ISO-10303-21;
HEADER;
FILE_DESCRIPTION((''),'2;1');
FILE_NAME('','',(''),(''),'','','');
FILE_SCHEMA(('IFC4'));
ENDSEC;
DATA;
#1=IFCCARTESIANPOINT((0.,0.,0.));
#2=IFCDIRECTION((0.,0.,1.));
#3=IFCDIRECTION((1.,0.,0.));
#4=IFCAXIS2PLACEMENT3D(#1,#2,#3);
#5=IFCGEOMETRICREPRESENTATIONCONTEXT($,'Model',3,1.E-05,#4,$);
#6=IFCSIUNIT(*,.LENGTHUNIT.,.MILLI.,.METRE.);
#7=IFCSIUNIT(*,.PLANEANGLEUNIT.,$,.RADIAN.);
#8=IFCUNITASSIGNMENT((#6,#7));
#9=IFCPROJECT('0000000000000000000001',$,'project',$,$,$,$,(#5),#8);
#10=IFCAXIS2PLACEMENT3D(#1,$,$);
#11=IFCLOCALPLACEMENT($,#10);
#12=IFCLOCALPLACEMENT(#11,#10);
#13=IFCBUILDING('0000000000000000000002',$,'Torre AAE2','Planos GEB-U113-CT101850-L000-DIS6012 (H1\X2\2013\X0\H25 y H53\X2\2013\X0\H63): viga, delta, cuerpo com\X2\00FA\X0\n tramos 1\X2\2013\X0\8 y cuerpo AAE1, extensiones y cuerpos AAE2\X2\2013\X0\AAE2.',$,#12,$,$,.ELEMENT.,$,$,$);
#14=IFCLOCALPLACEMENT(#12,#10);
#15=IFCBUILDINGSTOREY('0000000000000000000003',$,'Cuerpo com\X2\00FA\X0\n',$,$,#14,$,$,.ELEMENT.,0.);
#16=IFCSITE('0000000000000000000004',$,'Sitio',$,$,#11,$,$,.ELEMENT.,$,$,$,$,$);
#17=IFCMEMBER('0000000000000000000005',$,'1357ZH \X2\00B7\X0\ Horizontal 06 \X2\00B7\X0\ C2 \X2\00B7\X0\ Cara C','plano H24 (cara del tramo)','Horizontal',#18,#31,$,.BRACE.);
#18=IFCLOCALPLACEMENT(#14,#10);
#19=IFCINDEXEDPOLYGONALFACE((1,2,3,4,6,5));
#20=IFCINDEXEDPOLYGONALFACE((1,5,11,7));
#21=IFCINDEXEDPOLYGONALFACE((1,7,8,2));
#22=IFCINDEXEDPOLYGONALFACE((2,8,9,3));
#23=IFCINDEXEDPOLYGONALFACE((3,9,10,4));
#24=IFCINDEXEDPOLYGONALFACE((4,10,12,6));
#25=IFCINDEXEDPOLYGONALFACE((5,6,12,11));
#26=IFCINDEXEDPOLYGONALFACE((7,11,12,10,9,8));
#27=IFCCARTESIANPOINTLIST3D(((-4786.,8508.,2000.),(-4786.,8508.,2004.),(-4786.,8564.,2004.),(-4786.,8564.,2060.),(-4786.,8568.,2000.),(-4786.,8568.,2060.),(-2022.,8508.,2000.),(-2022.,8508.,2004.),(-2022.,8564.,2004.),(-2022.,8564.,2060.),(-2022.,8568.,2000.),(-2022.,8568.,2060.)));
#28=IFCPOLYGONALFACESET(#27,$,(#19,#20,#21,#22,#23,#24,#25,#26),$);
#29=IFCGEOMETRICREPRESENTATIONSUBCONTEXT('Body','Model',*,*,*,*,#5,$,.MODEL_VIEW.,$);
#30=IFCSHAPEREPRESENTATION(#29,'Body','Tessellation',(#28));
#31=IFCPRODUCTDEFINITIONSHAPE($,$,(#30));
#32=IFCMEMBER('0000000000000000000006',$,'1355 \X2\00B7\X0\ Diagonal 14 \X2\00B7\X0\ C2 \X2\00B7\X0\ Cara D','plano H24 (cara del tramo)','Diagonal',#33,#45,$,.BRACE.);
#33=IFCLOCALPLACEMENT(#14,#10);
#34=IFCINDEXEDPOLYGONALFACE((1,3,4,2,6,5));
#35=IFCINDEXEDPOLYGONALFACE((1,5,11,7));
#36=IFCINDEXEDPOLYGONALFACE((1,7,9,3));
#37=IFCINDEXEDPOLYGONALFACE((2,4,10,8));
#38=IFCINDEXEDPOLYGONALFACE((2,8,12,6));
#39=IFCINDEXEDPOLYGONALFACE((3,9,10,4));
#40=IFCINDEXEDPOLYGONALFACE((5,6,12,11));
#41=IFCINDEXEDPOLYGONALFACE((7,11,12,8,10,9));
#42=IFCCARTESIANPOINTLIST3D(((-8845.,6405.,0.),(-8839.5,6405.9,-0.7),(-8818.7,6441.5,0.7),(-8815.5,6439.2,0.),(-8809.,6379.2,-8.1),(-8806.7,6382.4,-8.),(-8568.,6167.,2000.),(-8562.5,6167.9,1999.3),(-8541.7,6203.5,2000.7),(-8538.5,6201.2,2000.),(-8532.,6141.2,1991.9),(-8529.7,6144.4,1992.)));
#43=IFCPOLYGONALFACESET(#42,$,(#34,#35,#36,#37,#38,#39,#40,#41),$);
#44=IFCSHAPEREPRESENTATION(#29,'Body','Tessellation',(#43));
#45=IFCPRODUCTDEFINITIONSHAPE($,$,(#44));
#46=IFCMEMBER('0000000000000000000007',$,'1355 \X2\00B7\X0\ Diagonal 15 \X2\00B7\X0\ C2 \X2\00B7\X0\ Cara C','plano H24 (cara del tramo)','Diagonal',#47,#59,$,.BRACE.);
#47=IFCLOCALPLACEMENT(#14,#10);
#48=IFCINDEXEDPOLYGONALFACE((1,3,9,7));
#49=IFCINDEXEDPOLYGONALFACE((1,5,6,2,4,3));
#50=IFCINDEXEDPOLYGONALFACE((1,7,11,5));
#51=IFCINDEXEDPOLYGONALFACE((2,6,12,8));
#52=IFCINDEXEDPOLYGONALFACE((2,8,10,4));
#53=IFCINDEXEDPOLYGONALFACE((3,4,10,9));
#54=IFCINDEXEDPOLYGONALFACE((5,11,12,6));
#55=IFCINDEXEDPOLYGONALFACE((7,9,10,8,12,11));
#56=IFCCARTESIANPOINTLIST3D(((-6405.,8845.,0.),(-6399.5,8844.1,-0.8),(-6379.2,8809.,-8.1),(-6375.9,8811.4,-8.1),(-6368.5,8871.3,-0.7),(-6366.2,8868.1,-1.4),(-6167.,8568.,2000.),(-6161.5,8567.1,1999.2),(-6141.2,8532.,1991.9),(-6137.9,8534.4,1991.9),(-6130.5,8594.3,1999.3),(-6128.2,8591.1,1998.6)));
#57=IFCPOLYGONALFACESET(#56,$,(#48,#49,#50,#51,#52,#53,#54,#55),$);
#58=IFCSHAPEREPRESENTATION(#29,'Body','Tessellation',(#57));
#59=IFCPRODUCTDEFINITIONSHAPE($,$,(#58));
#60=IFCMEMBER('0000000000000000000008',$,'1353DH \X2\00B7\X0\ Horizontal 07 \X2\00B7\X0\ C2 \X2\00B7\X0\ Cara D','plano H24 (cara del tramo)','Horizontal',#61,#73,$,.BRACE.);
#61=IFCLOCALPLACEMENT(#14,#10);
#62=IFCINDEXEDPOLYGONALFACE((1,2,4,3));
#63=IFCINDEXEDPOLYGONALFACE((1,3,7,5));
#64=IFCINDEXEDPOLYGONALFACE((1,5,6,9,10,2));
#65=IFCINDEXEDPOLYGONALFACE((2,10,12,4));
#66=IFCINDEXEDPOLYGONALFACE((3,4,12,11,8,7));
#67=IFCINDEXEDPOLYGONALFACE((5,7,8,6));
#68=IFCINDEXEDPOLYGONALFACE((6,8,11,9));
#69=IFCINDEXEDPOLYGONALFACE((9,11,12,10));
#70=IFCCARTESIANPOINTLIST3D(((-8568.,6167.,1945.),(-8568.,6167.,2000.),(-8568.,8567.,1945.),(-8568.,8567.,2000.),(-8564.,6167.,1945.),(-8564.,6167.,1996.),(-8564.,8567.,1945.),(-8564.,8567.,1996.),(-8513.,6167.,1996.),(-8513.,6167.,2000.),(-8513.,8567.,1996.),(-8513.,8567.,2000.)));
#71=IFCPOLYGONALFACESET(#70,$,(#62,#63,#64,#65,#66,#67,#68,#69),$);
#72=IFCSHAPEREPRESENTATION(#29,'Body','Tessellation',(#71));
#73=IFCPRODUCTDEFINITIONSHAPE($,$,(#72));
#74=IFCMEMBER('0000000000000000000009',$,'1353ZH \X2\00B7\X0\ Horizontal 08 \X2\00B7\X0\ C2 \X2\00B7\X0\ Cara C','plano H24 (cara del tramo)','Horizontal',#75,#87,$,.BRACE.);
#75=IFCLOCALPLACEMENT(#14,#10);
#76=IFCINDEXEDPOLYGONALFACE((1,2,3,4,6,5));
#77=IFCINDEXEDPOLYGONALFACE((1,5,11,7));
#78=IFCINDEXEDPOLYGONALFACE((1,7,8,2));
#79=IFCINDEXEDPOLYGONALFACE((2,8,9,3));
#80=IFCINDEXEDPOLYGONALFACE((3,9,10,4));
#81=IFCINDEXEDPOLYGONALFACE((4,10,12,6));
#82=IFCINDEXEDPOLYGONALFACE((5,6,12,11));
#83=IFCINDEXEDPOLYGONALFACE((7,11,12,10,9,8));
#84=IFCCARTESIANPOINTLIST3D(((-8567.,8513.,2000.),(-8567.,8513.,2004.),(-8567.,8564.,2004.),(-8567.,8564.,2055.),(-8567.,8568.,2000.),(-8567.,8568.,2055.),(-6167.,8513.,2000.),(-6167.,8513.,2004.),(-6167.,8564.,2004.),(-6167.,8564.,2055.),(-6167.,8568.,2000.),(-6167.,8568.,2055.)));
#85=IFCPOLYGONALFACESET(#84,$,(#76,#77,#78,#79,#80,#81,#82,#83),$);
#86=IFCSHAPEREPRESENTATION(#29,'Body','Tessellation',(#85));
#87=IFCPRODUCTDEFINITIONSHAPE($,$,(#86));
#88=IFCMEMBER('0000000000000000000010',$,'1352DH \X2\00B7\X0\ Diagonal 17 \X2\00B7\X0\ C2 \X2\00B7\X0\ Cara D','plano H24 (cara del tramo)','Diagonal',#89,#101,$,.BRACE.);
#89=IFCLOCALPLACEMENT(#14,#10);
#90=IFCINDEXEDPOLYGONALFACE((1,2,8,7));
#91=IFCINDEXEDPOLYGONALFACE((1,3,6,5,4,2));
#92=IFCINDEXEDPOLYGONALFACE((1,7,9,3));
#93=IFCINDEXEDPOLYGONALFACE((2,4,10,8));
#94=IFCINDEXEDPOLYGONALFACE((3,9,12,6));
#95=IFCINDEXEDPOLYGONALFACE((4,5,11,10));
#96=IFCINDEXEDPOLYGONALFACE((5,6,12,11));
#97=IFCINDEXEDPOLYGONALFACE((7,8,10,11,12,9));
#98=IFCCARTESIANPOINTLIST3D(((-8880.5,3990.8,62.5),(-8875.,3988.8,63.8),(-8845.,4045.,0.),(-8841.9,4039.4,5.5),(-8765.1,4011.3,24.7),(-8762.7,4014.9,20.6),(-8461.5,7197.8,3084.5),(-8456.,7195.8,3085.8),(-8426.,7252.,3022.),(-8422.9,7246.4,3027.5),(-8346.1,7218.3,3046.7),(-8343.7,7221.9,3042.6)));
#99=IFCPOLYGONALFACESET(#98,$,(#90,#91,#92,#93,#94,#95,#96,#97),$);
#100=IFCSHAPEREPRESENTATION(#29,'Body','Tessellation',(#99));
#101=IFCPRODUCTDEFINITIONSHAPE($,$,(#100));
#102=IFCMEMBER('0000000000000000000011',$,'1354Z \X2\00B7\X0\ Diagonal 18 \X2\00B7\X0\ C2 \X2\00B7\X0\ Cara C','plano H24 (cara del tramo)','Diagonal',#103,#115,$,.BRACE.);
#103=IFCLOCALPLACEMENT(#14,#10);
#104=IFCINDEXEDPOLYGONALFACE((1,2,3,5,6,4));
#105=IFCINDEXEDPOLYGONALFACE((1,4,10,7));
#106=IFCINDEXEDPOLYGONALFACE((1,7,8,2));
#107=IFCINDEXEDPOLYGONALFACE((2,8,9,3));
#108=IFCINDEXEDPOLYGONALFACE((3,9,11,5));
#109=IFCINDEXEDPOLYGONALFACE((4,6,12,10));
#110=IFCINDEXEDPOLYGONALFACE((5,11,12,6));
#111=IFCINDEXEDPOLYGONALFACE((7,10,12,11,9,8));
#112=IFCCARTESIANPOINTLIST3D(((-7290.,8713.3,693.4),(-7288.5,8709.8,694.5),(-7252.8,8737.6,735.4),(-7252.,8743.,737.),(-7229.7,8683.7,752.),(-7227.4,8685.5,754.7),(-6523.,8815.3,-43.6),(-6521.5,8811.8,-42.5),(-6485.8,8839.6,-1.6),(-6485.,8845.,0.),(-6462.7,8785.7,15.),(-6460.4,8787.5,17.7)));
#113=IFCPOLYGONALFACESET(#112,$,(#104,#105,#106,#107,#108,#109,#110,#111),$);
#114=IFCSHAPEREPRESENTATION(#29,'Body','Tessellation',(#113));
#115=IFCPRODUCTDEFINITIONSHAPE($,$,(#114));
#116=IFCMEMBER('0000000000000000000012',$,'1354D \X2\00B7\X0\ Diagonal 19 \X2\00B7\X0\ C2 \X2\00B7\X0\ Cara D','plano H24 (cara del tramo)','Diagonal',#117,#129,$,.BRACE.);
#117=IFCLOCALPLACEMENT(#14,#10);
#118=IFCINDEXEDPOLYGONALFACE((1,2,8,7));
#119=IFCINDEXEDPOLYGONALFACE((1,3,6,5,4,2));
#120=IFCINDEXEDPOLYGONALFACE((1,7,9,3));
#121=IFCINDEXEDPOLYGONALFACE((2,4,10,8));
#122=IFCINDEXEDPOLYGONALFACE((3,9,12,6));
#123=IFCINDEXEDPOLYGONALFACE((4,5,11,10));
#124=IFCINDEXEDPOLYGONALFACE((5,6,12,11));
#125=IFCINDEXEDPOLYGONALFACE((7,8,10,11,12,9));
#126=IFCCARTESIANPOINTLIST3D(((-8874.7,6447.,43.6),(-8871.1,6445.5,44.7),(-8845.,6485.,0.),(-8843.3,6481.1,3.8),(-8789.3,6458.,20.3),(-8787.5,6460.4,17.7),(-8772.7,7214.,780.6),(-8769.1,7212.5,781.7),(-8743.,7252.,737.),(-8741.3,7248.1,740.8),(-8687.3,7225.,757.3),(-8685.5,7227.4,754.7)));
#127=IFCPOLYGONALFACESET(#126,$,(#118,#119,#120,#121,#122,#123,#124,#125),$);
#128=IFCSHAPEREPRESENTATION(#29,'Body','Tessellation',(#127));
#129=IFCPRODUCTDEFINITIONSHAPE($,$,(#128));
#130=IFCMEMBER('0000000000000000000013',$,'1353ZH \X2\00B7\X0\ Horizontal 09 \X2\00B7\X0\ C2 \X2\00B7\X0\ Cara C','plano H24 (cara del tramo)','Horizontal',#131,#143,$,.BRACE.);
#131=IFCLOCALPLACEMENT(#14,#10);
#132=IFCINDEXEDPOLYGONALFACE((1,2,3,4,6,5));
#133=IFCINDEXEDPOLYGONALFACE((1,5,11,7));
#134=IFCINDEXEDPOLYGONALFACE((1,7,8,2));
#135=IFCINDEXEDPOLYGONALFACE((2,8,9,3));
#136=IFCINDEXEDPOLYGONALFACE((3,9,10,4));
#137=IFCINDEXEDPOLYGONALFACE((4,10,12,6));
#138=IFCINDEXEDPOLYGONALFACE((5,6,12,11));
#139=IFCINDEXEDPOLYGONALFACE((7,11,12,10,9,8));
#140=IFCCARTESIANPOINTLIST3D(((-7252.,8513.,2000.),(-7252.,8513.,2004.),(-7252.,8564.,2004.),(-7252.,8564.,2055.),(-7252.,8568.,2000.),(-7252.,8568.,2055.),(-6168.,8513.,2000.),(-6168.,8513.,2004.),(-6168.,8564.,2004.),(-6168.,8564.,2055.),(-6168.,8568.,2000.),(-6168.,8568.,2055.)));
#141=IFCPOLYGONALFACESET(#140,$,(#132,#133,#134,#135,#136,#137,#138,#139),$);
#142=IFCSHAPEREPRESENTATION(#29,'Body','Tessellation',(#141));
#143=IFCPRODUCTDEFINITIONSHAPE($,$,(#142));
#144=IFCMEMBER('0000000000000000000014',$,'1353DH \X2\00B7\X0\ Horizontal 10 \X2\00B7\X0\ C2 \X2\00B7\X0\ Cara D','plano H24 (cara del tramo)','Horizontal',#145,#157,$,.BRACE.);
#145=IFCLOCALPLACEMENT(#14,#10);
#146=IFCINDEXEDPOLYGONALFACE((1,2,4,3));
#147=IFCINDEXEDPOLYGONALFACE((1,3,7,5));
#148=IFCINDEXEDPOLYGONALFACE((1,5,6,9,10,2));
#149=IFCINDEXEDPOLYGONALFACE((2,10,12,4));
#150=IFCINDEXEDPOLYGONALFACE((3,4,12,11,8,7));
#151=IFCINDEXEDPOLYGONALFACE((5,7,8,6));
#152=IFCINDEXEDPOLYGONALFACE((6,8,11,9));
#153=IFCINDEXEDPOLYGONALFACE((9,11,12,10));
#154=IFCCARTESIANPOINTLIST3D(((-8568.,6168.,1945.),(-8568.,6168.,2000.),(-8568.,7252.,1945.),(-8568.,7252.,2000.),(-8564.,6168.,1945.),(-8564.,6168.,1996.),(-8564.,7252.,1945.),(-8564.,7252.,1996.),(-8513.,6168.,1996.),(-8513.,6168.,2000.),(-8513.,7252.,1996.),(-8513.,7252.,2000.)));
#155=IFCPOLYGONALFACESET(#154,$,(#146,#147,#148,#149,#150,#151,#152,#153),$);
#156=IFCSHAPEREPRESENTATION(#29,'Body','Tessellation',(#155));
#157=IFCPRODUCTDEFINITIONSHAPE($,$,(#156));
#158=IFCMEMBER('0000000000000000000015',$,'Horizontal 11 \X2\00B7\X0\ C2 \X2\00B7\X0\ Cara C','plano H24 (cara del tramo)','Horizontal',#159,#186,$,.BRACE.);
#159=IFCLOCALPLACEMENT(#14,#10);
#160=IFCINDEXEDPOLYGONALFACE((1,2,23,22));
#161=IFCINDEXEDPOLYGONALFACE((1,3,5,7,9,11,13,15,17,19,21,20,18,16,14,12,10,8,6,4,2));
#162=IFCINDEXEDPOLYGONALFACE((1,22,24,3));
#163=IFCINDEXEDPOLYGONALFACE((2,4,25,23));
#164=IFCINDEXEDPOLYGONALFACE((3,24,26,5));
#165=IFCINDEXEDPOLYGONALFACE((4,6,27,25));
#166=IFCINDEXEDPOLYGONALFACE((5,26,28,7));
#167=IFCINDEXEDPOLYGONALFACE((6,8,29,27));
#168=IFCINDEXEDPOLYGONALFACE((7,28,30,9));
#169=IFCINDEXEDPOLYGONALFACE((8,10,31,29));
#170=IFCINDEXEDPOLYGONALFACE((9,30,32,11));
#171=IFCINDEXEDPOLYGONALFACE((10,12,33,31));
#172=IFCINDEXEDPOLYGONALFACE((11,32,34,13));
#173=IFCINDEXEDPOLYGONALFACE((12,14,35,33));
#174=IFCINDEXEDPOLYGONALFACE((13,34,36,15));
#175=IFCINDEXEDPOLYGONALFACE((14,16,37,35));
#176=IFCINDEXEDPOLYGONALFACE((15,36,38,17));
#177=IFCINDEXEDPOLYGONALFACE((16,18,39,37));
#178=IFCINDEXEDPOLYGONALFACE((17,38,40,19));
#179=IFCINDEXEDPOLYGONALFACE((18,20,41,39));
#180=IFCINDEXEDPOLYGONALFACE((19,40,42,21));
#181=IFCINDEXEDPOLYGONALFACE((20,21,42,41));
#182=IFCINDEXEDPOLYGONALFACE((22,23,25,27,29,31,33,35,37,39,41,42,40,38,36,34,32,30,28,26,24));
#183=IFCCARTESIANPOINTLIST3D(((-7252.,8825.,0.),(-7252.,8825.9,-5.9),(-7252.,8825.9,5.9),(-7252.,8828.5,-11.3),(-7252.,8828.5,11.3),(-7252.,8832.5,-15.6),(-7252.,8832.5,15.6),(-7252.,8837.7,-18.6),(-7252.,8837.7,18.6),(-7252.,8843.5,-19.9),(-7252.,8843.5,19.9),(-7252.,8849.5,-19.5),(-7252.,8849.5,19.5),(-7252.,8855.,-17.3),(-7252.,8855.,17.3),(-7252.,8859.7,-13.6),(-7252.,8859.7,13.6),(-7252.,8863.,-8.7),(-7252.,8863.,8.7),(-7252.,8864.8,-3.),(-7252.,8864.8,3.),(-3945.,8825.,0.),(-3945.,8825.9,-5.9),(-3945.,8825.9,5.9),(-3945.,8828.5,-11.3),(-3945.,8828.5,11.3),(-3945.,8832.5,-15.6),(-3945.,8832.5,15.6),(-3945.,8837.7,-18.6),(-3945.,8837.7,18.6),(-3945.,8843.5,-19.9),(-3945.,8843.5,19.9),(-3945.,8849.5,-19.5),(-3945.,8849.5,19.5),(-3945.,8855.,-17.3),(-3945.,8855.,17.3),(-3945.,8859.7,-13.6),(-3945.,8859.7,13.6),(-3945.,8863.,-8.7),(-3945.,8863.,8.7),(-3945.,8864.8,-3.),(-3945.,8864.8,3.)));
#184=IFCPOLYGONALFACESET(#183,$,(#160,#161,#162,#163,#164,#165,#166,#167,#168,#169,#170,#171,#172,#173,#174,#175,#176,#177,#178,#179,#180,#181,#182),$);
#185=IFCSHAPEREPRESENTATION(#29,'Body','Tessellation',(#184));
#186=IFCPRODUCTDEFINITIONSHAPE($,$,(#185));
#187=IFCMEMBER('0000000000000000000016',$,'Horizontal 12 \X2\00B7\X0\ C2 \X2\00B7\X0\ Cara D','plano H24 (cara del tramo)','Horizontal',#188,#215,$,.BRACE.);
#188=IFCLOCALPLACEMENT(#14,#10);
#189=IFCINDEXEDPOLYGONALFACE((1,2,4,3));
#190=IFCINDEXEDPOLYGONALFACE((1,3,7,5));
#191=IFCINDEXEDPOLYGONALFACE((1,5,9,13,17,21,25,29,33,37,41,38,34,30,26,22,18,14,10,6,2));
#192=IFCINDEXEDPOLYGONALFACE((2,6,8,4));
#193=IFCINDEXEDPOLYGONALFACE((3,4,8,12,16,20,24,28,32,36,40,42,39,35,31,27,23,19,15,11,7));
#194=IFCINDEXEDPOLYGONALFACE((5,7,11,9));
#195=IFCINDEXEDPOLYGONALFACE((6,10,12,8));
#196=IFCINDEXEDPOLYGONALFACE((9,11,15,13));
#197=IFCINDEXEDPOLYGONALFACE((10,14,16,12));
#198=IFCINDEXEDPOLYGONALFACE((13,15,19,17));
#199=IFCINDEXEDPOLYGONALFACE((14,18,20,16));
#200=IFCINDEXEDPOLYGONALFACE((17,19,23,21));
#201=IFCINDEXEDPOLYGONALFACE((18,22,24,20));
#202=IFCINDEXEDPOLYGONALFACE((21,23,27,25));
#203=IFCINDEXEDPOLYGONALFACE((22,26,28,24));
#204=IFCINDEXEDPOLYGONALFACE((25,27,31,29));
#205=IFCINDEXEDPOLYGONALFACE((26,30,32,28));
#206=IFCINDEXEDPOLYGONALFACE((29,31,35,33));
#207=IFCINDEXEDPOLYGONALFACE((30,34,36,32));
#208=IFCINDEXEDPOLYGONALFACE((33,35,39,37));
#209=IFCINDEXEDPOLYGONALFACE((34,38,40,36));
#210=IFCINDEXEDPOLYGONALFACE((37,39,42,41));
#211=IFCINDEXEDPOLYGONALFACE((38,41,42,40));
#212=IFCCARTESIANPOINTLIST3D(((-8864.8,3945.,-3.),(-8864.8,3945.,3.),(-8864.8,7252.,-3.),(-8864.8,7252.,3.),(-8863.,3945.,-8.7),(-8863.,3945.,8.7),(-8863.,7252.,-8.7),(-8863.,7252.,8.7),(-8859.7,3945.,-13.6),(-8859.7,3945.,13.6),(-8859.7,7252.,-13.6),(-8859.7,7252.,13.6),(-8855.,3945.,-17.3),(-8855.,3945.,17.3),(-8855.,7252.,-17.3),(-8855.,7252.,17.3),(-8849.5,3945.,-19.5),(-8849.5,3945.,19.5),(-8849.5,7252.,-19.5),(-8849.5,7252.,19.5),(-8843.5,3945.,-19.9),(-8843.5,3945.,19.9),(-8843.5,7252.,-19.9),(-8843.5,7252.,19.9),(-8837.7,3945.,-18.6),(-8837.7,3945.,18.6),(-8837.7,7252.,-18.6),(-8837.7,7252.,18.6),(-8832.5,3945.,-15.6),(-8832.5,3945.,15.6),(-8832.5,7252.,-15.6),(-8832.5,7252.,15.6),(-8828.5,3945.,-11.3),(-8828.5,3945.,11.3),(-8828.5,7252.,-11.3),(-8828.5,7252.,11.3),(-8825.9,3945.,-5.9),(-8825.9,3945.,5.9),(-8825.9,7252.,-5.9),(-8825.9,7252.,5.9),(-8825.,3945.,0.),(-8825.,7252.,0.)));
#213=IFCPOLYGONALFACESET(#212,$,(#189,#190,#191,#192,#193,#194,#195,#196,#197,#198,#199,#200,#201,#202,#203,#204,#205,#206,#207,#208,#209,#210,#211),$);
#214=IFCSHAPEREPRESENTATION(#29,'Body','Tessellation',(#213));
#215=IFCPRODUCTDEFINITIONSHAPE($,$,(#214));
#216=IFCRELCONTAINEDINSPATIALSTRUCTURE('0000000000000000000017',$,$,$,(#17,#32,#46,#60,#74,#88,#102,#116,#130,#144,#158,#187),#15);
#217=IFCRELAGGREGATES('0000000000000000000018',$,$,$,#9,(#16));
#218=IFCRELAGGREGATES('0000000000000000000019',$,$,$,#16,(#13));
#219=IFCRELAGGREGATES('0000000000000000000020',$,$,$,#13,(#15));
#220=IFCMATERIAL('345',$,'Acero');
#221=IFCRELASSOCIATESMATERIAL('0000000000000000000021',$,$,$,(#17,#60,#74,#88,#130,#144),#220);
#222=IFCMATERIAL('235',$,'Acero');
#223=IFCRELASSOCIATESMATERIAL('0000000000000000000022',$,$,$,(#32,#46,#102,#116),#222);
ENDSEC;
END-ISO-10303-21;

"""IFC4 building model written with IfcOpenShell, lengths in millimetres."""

from ifc_helpers import new_model, si_unit, frame, frame_2d, origin, origin_with_axes, place, context, subcontext, project, spatial, circle, l_section, extrude, material, element, save


model = new_model("IFC4")

# Units and contexts
model_context = context("Model", 3, precision=1e-05, world=origin_with_axes())
body_context = subcontext(model_context, "Body", "Model", "MODEL_VIEW")
ifc_project = project(units=[si_unit("LENGTHUNIT", "METRE", prefix="MILLI"), si_unit("PLANEANGLEUNIT", "RADIAN")], contexts=[model_context])

# Site, building, storey
site_placement = place(None, origin())
site = spatial("IfcSite", under=ifc_project, at=site_placement, Name="Sitio", CompositionType="ELEMENT")
building_placement = place(site_placement, origin())
building = spatial("IfcBuilding", under=site, at=building_placement, Name="Torre AAE2", Description="Planos GEB-U113-CT101850-L000-DIS6012 (H1–H25 y H53–H63): viga, delta, cuerpo común tramos 1–8 y cuerpo AAE1, extensiones y cuerpos AAE2–AAE2.", CompositionType="ELEMENT")
storey_placement = place(building_placement, origin())
storey = spatial("IfcBuildingStorey", under=building, at=storey_placement, Name="Cuerpo común", CompositionType="ELEMENT", Elevation=0.0)

# Members
ifc_material_1 = material(Name="345", Category="Acero")
ifc_material_2 = material(Name="235", Category="Acero")
for number, where, z_axis, x_axis, name in (
    (1, (-2022.0, 8568.0, 2000.0), (-1.0, 0.0, 0.0), (0.0, -1.0, 0.0), "1357ZH · Horizontal 06 · C2 · Cara C"),
):
    element("IfcMember", number, at=place(storey_placement, frame(where, z_axis=z_axis, x_axis=x_axis)), inside=storey, material=ifc_material_1, Name=name, Description="plano H24 (cara del tramo)", ObjectType="Horizontal", PredefinedType="BRACE", context=body_context, shape_type="SweptSolid", body=[
        extrude(l_section(Depth=60.0, Width=60.0, Thickness=4.0, at=frame_2d((30.0, 30.0))), None, (0.0, 0.0, 1.0), 2764.0),
    ])
for number, where, z_axis, x_axis, name in (
    (2, (-8845.0, 6405.0, 0.0), (0.136247, -0.117064, 0.983734), (0.79929, -0.573677, -0.178969), "1355 · Diagonal 14 · C2 · Cara D"),
    (3, (-6405.0, 8845.0, 0.0), (0.117064, -0.136247, 0.983734), (0.573677, -0.79929, -0.178969), "1355 · Diagonal 15 · C2 · Cara C"),
):
    element("IfcMember", number, at=place(storey_placement, frame(where, z_axis=z_axis, x_axis=x_axis)), inside=storey, material=ifc_material_2, Name=name, Description="plano H24 (cara del tramo)", ObjectType="Diagonal", PredefinedType="BRACE", context=body_context, shape_type="SweptSolid", body=[
        extrude(l_section(Depth=45.0, Width=45.0, Thickness=4.0, at=frame_2d((22.5, 22.5))), None, (0.0, 0.0, 1.0), 2033.1),
    ])
for number, where, z_axis, x_axis, name in (
    (4, (-8568.0, 6167.0, 2000.0), (0.0, 1.0, 0.0), (1.0, 0.0, 0.0), "1353DH · Horizontal 07 · C2 · Cara D"),
    (5, (-6167.0, 8568.0, 2000.0), (-1.0, 0.0, 0.0), (0.0, -1.0, 0.0), "1353ZH · Horizontal 08 · C2 · Cara C"),
):
    element("IfcMember", number, at=place(storey_placement, frame(where, z_axis=z_axis, x_axis=x_axis)), inside=storey, material=ifc_material_1, Name=name, Description="plano H24 (cara del tramo)", ObjectType="Horizontal", PredefinedType="BRACE", context=body_context, shape_type="SweptSolid", body=[
        extrude(l_section(Depth=55.0, Width=55.0, Thickness=4.0, at=frame_2d((27.5, 27.5))), None, (0.0, 0.0, 1.0), 2400.0),
    ])
member_1_placement = place(storey_placement, frame((-8426.0, 7252.0, 3022.0), z_axis=(-0.09466, -0.724519, -0.682724), x_axis=(0.91418, -0.334757, 0.228499)))
element("IfcMember", 6, at=member_1_placement, inside=storey, material=ifc_material_1, Name="1352DH · Diagonal 17 · C2 · Cara D", Description="plano H24 (cara del tramo)", ObjectType="Diagonal", PredefinedType="BRACE", context=body_context, shape_type="SweptSolid", body=[
    extrude(l_section(Depth=90.0, Width=90.0, Thickness=6.0, at=frame_2d((45.0, 45.0))), None, (0.0, 0.0, 1.0), 4426.4),
])
for number, where, z_axis, x_axis, name in (
    (7, (-7252.0, 8743.0, 737.0), (0.717775, 0.095454, -0.689701), (0.378781, -0.884687, 0.27176), "1354Z · Diagonal 18 · C2 · Cara C"),
    (8, (-8743.0, 7252.0, 737.0), (-0.095454, -0.717775, -0.689701), (0.884687, -0.378781, 0.27176), "1354D · Diagonal 19 · C2 · Cara D"),
):
    element("IfcMember", number, at=place(storey_placement, frame(where, z_axis=z_axis, x_axis=x_axis)), inside=storey, material=ifc_material_2, Name=name, Description="plano H24 (cara del tramo)", ObjectType="Diagonal", PredefinedType="BRACE", context=body_context, shape_type="SweptSolid", body=[
        extrude(l_section(Depth=65.0, Width=65.0, Thickness=4.0, at=frame_2d((32.5, 32.5))), None, (0.0, 0.0, 1.0), 1068.6),
    ])
for number, where, z_axis, x_axis, name in (
    (9, (-6168.0, 8568.0, 2000.0), (-1.0, 0.0, 0.0), (0.0, -1.0, 0.0), "1353ZH · Horizontal 09 · C2 · Cara C"),
    (10, (-8568.0, 6168.0, 2000.0), (0.0, 1.0, 0.0), (1.0, 0.0, 0.0), "1353DH · Horizontal 10 · C2 · Cara D"),
):
    element("IfcMember", number, at=place(storey_placement, frame(where, z_axis=z_axis, x_axis=x_axis)), inside=storey, material=ifc_material_1, Name=name, Description="plano H24 (cara del tramo)", ObjectType="Horizontal", PredefinedType="BRACE", context=body_context, shape_type="SweptSolid", body=[
        extrude(l_section(Depth=55.0, Width=55.0, Thickness=4.0, at=frame_2d((27.5, 27.5))), None, (0.0, 0.0, 1.0), 1084.0),
    ])
for number, where, z_axis, x_axis, name in (
    (11, (-7252.0, 8845.0, 0.0), (1.0, 0.0, 0.0), (0.0, -1.0, 0.0), "Horizontal 11 · C2 · Cara C"),
    (12, (-8845.0, 7252.0, 0.0), (0.0, -1.0, 0.0), (1.0, 0.0, 0.0), "Horizontal 12 · C2 · Cara D"),
):
    element("IfcMember", number, at=place(storey_placement, frame(where, z_axis=z_axis, x_axis=x_axis)), inside=storey, Name=name, Description="plano H24 (cara del tramo)", ObjectType="Horizontal", PredefinedType="BRACE", context=body_context, shape_type="SweptSolid", body=[
        extrude(circle(Radius=20.0), None, (0.0, 0.0, 1.0), 3307.0),
    ])

save(model, "model.ifc")
